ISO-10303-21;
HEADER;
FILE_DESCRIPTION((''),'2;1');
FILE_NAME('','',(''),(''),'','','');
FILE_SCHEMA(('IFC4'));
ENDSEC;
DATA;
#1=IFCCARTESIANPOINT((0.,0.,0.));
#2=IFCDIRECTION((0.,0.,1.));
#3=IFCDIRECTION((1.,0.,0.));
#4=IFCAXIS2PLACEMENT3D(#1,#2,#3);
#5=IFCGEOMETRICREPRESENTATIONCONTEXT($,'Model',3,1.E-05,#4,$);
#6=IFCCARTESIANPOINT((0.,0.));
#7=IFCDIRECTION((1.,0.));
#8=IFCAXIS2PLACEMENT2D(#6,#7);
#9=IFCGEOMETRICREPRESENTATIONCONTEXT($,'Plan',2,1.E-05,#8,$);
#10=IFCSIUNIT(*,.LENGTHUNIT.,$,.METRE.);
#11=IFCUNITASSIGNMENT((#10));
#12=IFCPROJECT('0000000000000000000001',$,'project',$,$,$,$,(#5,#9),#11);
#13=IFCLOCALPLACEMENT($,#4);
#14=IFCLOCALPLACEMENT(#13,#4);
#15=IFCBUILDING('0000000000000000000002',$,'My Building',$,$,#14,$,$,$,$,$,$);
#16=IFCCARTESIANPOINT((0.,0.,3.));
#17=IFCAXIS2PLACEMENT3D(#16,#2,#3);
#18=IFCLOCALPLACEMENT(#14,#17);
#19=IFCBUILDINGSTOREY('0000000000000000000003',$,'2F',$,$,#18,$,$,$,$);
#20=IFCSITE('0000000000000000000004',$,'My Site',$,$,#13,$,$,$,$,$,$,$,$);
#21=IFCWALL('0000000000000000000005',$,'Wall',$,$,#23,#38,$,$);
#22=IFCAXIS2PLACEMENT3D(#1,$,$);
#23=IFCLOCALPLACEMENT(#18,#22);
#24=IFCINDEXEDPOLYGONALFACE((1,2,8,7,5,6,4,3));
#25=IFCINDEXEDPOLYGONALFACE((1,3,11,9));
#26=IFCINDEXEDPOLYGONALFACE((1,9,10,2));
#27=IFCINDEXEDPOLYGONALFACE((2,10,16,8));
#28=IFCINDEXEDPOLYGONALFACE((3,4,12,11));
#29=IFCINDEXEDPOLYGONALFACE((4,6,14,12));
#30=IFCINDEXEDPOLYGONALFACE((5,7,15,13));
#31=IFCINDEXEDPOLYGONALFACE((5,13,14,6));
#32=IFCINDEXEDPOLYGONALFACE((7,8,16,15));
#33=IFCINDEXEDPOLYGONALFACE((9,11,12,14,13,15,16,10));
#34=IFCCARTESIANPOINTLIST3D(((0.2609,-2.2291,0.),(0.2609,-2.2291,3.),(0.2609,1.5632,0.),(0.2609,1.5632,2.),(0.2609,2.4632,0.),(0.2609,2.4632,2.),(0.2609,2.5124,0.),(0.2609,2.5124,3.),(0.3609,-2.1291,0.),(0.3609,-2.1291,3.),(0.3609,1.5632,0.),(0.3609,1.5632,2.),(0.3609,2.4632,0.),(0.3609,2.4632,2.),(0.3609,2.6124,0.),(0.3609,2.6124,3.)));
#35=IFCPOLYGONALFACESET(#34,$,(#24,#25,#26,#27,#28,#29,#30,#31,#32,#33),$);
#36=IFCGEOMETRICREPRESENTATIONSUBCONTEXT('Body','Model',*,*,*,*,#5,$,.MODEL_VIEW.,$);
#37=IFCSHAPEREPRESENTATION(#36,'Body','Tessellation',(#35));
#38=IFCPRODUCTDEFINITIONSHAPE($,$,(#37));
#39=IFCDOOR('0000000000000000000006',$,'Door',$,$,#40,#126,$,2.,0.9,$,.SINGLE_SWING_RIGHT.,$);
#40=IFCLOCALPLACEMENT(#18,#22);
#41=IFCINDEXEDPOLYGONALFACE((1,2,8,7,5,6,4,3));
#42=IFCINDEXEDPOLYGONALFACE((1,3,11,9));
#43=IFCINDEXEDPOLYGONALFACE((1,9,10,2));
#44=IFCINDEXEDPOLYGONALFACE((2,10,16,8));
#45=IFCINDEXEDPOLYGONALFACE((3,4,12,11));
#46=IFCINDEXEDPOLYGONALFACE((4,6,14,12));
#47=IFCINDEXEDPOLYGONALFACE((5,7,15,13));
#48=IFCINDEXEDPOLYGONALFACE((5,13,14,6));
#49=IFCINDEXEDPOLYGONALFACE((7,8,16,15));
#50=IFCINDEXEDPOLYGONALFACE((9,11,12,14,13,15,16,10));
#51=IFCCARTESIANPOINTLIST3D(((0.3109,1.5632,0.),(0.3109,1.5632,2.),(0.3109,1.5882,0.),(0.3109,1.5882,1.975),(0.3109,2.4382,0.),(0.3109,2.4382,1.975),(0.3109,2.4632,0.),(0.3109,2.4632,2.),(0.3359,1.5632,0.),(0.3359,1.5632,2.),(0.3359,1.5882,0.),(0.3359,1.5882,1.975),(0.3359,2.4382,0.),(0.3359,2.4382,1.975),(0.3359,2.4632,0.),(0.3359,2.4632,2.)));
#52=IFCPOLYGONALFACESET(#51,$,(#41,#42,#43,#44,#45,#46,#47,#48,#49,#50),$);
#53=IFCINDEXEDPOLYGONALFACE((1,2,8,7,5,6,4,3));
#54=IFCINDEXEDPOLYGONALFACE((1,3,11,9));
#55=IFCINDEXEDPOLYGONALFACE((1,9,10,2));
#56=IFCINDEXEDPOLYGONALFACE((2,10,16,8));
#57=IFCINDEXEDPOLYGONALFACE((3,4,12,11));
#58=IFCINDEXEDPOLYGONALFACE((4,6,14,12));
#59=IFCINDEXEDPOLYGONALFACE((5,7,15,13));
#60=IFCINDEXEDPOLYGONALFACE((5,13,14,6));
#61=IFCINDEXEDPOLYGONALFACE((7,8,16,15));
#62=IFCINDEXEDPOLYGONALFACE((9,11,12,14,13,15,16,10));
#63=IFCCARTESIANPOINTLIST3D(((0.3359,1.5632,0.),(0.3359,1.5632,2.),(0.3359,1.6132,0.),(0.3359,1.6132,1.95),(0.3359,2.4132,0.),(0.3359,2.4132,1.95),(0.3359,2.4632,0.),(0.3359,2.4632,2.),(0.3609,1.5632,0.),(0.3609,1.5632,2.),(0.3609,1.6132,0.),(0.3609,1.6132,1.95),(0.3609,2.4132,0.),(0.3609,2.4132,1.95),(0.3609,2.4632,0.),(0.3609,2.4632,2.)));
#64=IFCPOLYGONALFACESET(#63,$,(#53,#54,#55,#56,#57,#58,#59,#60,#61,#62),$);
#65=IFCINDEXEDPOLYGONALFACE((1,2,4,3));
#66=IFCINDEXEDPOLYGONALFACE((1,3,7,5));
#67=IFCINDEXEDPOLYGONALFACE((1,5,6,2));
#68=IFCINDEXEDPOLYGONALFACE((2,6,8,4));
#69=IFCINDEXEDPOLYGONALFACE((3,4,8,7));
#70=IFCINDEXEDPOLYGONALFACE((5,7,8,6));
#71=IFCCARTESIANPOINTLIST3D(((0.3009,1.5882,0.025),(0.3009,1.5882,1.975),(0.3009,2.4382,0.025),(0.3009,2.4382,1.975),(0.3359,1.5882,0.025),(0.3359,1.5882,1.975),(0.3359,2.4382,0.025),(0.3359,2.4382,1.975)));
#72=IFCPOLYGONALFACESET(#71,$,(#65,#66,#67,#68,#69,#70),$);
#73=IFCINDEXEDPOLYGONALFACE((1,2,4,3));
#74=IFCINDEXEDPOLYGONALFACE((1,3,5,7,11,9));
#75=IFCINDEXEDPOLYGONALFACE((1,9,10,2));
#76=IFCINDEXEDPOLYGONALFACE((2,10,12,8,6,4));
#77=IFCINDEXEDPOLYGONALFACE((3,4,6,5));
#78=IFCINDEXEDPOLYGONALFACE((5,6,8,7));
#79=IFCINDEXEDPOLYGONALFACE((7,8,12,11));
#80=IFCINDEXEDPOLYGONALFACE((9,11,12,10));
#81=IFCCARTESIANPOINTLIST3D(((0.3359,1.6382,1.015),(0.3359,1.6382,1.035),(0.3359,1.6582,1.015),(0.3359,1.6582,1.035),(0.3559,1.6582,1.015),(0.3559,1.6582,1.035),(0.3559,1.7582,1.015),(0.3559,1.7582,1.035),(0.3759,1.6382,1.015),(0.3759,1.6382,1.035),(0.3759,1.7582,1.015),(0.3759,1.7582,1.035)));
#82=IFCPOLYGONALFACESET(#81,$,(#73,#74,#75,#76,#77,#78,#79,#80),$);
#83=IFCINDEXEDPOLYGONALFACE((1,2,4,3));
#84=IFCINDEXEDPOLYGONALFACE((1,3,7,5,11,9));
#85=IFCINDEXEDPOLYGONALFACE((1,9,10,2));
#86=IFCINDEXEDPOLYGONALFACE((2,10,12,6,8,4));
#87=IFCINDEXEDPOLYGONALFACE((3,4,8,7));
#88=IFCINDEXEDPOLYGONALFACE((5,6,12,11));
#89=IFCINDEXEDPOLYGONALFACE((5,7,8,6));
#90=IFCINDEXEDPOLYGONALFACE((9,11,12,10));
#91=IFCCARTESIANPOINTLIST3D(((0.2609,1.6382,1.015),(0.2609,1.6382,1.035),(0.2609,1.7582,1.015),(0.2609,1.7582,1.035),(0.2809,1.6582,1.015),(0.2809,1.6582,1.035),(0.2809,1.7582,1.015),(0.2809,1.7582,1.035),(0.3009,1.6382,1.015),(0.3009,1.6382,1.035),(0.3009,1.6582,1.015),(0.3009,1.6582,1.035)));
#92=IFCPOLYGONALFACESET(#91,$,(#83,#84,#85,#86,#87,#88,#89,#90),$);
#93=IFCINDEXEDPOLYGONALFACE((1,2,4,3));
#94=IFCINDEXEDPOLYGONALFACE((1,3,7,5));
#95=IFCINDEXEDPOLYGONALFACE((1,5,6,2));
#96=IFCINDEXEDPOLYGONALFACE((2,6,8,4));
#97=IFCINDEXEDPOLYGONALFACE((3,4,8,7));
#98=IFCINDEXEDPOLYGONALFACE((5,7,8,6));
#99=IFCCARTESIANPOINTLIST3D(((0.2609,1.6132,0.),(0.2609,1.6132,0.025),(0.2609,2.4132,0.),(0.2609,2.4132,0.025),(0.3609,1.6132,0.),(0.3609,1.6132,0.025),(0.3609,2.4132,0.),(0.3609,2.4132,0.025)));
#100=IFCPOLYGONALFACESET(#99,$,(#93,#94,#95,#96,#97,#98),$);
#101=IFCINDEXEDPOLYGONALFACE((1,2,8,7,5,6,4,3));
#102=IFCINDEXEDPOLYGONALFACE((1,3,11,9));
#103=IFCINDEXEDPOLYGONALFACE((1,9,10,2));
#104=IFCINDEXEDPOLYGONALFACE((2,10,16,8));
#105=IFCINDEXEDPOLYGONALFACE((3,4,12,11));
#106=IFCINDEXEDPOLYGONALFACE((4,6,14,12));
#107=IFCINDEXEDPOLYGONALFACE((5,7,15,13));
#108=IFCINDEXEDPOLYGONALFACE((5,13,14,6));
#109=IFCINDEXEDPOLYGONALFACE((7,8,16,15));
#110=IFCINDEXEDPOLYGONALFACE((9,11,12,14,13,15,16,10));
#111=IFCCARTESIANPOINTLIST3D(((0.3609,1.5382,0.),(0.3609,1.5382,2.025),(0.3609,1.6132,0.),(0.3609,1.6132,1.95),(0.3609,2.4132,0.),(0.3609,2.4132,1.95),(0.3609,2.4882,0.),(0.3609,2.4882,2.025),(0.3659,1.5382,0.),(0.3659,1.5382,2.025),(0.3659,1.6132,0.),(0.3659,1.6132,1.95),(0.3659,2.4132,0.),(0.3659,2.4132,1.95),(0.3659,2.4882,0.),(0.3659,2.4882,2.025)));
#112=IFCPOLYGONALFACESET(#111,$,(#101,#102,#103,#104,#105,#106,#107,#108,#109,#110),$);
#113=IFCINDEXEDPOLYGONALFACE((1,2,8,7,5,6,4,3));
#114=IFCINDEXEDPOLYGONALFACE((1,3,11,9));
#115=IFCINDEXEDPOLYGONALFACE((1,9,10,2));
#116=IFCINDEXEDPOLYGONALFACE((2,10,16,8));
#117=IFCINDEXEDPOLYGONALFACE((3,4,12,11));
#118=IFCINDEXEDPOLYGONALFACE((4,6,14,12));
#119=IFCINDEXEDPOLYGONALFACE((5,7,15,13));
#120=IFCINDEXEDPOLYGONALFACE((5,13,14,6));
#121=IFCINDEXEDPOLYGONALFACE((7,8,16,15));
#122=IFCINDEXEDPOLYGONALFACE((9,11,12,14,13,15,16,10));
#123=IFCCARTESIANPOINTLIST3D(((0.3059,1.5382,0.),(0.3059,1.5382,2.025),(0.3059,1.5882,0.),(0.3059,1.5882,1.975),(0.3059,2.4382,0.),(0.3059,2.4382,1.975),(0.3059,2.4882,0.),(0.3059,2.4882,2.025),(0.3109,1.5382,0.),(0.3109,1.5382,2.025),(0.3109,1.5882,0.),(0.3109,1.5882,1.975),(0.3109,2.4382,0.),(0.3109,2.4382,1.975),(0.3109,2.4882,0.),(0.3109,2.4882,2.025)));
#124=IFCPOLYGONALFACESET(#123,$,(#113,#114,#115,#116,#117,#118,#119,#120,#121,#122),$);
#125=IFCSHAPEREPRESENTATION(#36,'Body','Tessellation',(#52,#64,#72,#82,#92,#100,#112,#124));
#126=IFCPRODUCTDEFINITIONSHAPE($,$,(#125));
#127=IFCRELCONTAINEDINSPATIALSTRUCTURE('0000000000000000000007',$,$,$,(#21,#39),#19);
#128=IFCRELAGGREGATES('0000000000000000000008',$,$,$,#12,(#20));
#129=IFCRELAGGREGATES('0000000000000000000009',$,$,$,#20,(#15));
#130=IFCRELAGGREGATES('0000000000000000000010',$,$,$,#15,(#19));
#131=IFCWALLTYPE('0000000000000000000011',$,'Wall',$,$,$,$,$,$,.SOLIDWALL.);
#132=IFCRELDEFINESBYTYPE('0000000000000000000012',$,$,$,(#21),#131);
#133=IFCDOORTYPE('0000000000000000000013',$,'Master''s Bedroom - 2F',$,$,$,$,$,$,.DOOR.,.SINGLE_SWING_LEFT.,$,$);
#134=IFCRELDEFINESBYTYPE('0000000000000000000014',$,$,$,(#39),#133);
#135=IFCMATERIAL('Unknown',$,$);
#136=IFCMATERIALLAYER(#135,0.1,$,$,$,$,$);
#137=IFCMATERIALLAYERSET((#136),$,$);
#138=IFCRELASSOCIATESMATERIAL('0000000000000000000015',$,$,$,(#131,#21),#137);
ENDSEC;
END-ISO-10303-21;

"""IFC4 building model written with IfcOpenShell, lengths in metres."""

from ifc_helpers import new_model, entity, si_unit, frame, origin_with_axes, origin_2d_with_axis, place, context, subcontext, project, spatial, line, indexed_curve, outline, extrude, shape, source, transform, mapped, material, layer, layer_set, layer_usage, type_object, type_shapes, element, fill, save


model = new_model("IFC4")

# Units and contexts
model_context = context("Model", 3, precision=1e-05, world=origin_with_axes())
plan_context = context("Plan", 2, precision=1e-05, world=origin_2d_with_axis())
body_context_1 = subcontext(model_context, "Body", "Model", "MODEL_VIEW")
body_context_2 = subcontext(plan_context, "Body", "Plan", "PLAN_VIEW")
ifc_project = project(units=[si_unit("LENGTHUNIT", "METRE")], contexts=[model_context, plan_context])

# Site, building, storey
site_placement = place(None, origin_with_axes())
site = spatial("IfcSite", under=ifc_project, at=site_placement, Name="My Site")
building_placement = place(site_placement, origin_with_axes())
building = spatial("IfcBuilding", under=site, at=building_placement, Name="My Building")
storey_placement = place(building_placement, frame((0.0, 0.0, 3.0), z_axis=(0.0, 0.0, 1.0), x_axis=(1.0, 0.0, 0.0)))
storey = spatial("IfcBuildingStorey", under=building, at=storey_placement, Name="2F")

# Shared definitions
ifc_material = material(Name="Unknown")

# Shared definitions
ifc_layer_1 = layer(ifc_material, 0.1)
ifc_layer_set_1 = layer_set([ifc_layer_1])
wall_type = type_object("IfcWallType", Name="Wall", PredefinedType="SOLIDWALL", material=ifc_layer_set_1)

# Wall, opening, door
ifc_layer_usage_1 = layer_usage(ifc_layer_set_1, "AXIS2", "POSITIVE", 0.0)
wall_1_placement = place(storey_placement, frame((0.2609, 2.5124, 0.0), z_axis=(0.0, 0.0, 1.0), x_axis=(0.0, -1.0, 0.0)))
wall_1 = element("IfcWall", 1, at=wall_1_placement, inside=storey, type_object=wall_type, material=ifc_layer_usage_1, Name="Wall", context=body_context_1, shape_type="SweptSolid", body=[
    extrude(outline(indexed_curve([(0.0, 0.0), (-0.1, 0.1), (4.6414, 0.1), (4.7414, 0.0)], segments=[line(1, 2, 3, 4, 1)])), origin_with_axes(), (0.0, 0.0, 1.0), 3.0),
])
shared_shape_1 = source(origin_with_axes(), body_context_1, "Body", "SweptSolid", [
    extrude(outline(indexed_curve([(0.0, 0.0), (0.9, 0.0), (0.9, 2.0), (0.0, 2.0)], segments=[line(1, 2, 3, 4, 1)])), frame((0.0, -0.6, 0.0), z_axis=(0.0, -1.0, 0.0), x_axis=(1.0, 0.0, 0.0)), (0.0, 0.0, -1.0), 1.2),
])
opening_1_placement = place(wall_1_placement, frame((0.9491, 0.1, 0.0), z_axis=(0.0, 0.0, 1.0), x_axis=(-1.0, 0.0, 0.0)))
opening_1 = element("IfcOpeningElement", 2, at=opening_1_placement, cuts=wall_1, PredefinedType="OPENING", context=body_context_1, shape_type="MappedRepresentation", body=[
    mapped(shared_shape_1, transform((0.0, 0.0, 0.0), x_axis=(1.0, 0.0, 0.0), y_axis=(0.0, 1.0, 0.0), z_axis=(0.0, 0.0, 1.0), scale=1.0)),
])
door_type_1 = type_object("IfcDoorType", Name="Master's Bedroom - 2F", OperationType="SINGLE_SWING_LEFT", PredefinedType="DOOR")
shared_shape_2 = source(origin_with_axes(), body_context_1, "Body", "SweptSolid", [
    extrude(outline(indexed_curve([(0.0, 0.0), (0.0, 2.0), (0.9, 2.0), (0.9, 0.0), (0.875, 0.0), (0.875, 1.975), (0.025, 1.975), (0.025, 0.0)], segments=[line(1, 2, 3, 4, 5, 6, 7, 8, 1)])), frame((0.0, 0.025, 0.0), z_axis=(0.0, -1.0, 0.0), x_axis=(1.0, 0.0, 0.0)), (0.0, 0.0, -1.0), 0.025),
    extrude(outline(indexed_curve([(0.0, 0.0), (0.0, 2.0), (0.9, 2.0), (0.9, 0.0), (0.85, 0.0), (0.85, 1.95), (0.05, 1.95), (0.05, 0.0)], segments=[line(1, 2, 3, 4, 5, 6, 7, 8, 1)])), frame((0.0, 0.0, 0.0), z_axis=(0.0, -1.0, 0.0), x_axis=(1.0, 0.0, 0.0)), (0.0, 0.0, -1.0), 0.025),
    extrude(outline(indexed_curve([(0.0, 0.0), (0.85, 0.0), (0.85, 0.035), (0.0, 0.035)], segments=[line(1, 2, 3, 4, 1)])), frame((0.025, 0.025, 0.025), z_axis=(0.0, 0.0, 1.0), x_axis=(1.0, 0.0, 0.0)), (0.0, 0.0, 1.0), 1.95),
    extrude(outline(indexed_curve([(0.0, 0.0), (0.0, -0.04), (0.12, -0.04), (0.12, -0.02), (0.02, -0.02), (0.02, 0.0)], segments=[line(1, 2, 3, 4, 5, 6, 1)])), frame((0.075, 0.025, 1.015), z_axis=(0.0, 0.0, 1.0), x_axis=(1.0, 0.0, 0.0)), (0.0, 0.0, 1.0), 0.02),
    extrude(outline(indexed_curve([(0.0, 0.0), (0.0, 0.04), (0.12, 0.04), (0.12, 0.02), (0.02, 0.02), (0.02, 0.0)], segments=[line(1, 2, 3, 4, 5, 6, 1)])), frame((0.075, 0.06, 1.015), z_axis=(0.0, 0.0, 1.0), x_axis=(1.0, 0.0, 0.0)), (0.0, 0.0, 1.0), 0.02),
    extrude(outline(indexed_curve([(0.0, 0.0), (0.8, 0.0), (0.8, 0.1), (0.0, 0.1)], segments=[line(1, 2, 3, 4, 1)])), frame((0.05, 0.0, 0.0), z_axis=(0.0, 0.0, 1.0), x_axis=(1.0, 0.0, 0.0)), (0.0, 0.0, 1.0), 0.025),
    extrude(outline(indexed_curve([(0.0, 0.0), (0.0, 2.025), (0.95, 2.025), (0.95, 0.0), (0.875, 0.0), (0.875, 1.95), (0.075, 1.95), (0.075, 0.0)], segments=[line(1, 2, 3, 4, 5, 6, 7, 8, 1)])), frame((-0.025, -0.005, 0.0), z_axis=(0.0, -1.0, 0.0), x_axis=(1.0, 0.0, 0.0)), (0.0, 0.0, -1.0), 0.005),
    extrude(outline(indexed_curve([(0.0, 0.0), (0.0, 2.025), (0.95, 2.025), (0.95, 0.0), (0.9, 0.0), (0.9, 1.975), (0.05, 1.975), (0.05, 0.0)], segments=[line(1, 2, 3, 4, 5, 6, 7, 8, 1)])), frame((-0.025, 0.05, 0.0), z_axis=(0.0, -1.0, 0.0), x_axis=(1.0, 0.0, 0.0)), (0.0, 0.0, -1.0), 0.005),
])
shared_shape_3 = source(origin_with_axes(), body_context_2, "Body", "Curve2D", [
    entity("IfcIndexedPolyCurve", entity("IfcCartesianPointList2D", [[0.0, 0.0], [0.0, 0.05], [0.025, 0.05], [0.025, 0.025], [0.05, 0.025], [0.05, 0.0]]), [entity("IfcLineIndex", [1, 2, 3, 4, 5, 6, 1])]),
    entity("IfcIndexedPolyCurve", entity("IfcCartesianPointList2D", [[0.9, 0.0], [0.9, 0.05], [0.875, 0.05], [0.875, 0.025], [0.85, 0.025], [0.85, 0.0]]), [entity("IfcLineIndex", [1, 2, 3, 4, 5, 6, 1])]),
    entity("IfcTrimmedCurve", entity("IfcEllipse", entity("IfcAxis2Placement2D", entity("IfcCartesianPoint", [0.84, 0.05]), entity("IfcDirection", [1.0, 0.0])), 0.815, 0.85), [entity("IfcCartesianPoint", [0.84, 0.9])], [entity("IfcCartesianPoint", [0.025, 0.05])], True, "CARTESIAN"),
    entity("IfcIndexedPolyCurve", entity("IfcCartesianPointList2D", [[0.875, 0.05], [0.84, 0.05], [0.84, 0.9], [0.875, 0.9]]), [entity("IfcLineIndex", [1, 2, 3, 4, 1])]),
])
type_shapes(door_type_1, [shared_shape_2, shared_shape_3])
door_1_placement = place(opening_1_placement, frame((0.0, 0.0, 0.0), z_axis=(0.0, 0.0, 1.0), x_axis=(1.0, 0.0, 0.0)))
door_1 = element("IfcDoor", 3, at=door_1_placement, inside=storey, type_object=door_type_1, Name="Door", OperationType="SINGLE_SWING_RIGHT", OverallHeight=2.0, OverallWidth=0.9, shapes=[
    shape(body_context_1, "Body", "MappedRepresentation", [mapped(shared_shape_2, transform((0.0, 0.0, 0.0), x_axis=(1.0, 0.0, 0.0), y_axis=(0.0, 1.0, 0.0), z_axis=(0.0, 0.0, 1.0), scale=1.0))]),
    shape(body_context_2, "Body", "MappedRepresentation", [mapped(shared_shape_3, transform((0.0, 0.0, 0.0), x_axis=(1.0, 0.0, 0.0), y_axis=(0.0, 1.0, 0.0), z_axis=(0.0, 0.0, 1.0), scale=1.0))]),
])
fill(opening_1, door_1)

save(model, "model.ifc")
